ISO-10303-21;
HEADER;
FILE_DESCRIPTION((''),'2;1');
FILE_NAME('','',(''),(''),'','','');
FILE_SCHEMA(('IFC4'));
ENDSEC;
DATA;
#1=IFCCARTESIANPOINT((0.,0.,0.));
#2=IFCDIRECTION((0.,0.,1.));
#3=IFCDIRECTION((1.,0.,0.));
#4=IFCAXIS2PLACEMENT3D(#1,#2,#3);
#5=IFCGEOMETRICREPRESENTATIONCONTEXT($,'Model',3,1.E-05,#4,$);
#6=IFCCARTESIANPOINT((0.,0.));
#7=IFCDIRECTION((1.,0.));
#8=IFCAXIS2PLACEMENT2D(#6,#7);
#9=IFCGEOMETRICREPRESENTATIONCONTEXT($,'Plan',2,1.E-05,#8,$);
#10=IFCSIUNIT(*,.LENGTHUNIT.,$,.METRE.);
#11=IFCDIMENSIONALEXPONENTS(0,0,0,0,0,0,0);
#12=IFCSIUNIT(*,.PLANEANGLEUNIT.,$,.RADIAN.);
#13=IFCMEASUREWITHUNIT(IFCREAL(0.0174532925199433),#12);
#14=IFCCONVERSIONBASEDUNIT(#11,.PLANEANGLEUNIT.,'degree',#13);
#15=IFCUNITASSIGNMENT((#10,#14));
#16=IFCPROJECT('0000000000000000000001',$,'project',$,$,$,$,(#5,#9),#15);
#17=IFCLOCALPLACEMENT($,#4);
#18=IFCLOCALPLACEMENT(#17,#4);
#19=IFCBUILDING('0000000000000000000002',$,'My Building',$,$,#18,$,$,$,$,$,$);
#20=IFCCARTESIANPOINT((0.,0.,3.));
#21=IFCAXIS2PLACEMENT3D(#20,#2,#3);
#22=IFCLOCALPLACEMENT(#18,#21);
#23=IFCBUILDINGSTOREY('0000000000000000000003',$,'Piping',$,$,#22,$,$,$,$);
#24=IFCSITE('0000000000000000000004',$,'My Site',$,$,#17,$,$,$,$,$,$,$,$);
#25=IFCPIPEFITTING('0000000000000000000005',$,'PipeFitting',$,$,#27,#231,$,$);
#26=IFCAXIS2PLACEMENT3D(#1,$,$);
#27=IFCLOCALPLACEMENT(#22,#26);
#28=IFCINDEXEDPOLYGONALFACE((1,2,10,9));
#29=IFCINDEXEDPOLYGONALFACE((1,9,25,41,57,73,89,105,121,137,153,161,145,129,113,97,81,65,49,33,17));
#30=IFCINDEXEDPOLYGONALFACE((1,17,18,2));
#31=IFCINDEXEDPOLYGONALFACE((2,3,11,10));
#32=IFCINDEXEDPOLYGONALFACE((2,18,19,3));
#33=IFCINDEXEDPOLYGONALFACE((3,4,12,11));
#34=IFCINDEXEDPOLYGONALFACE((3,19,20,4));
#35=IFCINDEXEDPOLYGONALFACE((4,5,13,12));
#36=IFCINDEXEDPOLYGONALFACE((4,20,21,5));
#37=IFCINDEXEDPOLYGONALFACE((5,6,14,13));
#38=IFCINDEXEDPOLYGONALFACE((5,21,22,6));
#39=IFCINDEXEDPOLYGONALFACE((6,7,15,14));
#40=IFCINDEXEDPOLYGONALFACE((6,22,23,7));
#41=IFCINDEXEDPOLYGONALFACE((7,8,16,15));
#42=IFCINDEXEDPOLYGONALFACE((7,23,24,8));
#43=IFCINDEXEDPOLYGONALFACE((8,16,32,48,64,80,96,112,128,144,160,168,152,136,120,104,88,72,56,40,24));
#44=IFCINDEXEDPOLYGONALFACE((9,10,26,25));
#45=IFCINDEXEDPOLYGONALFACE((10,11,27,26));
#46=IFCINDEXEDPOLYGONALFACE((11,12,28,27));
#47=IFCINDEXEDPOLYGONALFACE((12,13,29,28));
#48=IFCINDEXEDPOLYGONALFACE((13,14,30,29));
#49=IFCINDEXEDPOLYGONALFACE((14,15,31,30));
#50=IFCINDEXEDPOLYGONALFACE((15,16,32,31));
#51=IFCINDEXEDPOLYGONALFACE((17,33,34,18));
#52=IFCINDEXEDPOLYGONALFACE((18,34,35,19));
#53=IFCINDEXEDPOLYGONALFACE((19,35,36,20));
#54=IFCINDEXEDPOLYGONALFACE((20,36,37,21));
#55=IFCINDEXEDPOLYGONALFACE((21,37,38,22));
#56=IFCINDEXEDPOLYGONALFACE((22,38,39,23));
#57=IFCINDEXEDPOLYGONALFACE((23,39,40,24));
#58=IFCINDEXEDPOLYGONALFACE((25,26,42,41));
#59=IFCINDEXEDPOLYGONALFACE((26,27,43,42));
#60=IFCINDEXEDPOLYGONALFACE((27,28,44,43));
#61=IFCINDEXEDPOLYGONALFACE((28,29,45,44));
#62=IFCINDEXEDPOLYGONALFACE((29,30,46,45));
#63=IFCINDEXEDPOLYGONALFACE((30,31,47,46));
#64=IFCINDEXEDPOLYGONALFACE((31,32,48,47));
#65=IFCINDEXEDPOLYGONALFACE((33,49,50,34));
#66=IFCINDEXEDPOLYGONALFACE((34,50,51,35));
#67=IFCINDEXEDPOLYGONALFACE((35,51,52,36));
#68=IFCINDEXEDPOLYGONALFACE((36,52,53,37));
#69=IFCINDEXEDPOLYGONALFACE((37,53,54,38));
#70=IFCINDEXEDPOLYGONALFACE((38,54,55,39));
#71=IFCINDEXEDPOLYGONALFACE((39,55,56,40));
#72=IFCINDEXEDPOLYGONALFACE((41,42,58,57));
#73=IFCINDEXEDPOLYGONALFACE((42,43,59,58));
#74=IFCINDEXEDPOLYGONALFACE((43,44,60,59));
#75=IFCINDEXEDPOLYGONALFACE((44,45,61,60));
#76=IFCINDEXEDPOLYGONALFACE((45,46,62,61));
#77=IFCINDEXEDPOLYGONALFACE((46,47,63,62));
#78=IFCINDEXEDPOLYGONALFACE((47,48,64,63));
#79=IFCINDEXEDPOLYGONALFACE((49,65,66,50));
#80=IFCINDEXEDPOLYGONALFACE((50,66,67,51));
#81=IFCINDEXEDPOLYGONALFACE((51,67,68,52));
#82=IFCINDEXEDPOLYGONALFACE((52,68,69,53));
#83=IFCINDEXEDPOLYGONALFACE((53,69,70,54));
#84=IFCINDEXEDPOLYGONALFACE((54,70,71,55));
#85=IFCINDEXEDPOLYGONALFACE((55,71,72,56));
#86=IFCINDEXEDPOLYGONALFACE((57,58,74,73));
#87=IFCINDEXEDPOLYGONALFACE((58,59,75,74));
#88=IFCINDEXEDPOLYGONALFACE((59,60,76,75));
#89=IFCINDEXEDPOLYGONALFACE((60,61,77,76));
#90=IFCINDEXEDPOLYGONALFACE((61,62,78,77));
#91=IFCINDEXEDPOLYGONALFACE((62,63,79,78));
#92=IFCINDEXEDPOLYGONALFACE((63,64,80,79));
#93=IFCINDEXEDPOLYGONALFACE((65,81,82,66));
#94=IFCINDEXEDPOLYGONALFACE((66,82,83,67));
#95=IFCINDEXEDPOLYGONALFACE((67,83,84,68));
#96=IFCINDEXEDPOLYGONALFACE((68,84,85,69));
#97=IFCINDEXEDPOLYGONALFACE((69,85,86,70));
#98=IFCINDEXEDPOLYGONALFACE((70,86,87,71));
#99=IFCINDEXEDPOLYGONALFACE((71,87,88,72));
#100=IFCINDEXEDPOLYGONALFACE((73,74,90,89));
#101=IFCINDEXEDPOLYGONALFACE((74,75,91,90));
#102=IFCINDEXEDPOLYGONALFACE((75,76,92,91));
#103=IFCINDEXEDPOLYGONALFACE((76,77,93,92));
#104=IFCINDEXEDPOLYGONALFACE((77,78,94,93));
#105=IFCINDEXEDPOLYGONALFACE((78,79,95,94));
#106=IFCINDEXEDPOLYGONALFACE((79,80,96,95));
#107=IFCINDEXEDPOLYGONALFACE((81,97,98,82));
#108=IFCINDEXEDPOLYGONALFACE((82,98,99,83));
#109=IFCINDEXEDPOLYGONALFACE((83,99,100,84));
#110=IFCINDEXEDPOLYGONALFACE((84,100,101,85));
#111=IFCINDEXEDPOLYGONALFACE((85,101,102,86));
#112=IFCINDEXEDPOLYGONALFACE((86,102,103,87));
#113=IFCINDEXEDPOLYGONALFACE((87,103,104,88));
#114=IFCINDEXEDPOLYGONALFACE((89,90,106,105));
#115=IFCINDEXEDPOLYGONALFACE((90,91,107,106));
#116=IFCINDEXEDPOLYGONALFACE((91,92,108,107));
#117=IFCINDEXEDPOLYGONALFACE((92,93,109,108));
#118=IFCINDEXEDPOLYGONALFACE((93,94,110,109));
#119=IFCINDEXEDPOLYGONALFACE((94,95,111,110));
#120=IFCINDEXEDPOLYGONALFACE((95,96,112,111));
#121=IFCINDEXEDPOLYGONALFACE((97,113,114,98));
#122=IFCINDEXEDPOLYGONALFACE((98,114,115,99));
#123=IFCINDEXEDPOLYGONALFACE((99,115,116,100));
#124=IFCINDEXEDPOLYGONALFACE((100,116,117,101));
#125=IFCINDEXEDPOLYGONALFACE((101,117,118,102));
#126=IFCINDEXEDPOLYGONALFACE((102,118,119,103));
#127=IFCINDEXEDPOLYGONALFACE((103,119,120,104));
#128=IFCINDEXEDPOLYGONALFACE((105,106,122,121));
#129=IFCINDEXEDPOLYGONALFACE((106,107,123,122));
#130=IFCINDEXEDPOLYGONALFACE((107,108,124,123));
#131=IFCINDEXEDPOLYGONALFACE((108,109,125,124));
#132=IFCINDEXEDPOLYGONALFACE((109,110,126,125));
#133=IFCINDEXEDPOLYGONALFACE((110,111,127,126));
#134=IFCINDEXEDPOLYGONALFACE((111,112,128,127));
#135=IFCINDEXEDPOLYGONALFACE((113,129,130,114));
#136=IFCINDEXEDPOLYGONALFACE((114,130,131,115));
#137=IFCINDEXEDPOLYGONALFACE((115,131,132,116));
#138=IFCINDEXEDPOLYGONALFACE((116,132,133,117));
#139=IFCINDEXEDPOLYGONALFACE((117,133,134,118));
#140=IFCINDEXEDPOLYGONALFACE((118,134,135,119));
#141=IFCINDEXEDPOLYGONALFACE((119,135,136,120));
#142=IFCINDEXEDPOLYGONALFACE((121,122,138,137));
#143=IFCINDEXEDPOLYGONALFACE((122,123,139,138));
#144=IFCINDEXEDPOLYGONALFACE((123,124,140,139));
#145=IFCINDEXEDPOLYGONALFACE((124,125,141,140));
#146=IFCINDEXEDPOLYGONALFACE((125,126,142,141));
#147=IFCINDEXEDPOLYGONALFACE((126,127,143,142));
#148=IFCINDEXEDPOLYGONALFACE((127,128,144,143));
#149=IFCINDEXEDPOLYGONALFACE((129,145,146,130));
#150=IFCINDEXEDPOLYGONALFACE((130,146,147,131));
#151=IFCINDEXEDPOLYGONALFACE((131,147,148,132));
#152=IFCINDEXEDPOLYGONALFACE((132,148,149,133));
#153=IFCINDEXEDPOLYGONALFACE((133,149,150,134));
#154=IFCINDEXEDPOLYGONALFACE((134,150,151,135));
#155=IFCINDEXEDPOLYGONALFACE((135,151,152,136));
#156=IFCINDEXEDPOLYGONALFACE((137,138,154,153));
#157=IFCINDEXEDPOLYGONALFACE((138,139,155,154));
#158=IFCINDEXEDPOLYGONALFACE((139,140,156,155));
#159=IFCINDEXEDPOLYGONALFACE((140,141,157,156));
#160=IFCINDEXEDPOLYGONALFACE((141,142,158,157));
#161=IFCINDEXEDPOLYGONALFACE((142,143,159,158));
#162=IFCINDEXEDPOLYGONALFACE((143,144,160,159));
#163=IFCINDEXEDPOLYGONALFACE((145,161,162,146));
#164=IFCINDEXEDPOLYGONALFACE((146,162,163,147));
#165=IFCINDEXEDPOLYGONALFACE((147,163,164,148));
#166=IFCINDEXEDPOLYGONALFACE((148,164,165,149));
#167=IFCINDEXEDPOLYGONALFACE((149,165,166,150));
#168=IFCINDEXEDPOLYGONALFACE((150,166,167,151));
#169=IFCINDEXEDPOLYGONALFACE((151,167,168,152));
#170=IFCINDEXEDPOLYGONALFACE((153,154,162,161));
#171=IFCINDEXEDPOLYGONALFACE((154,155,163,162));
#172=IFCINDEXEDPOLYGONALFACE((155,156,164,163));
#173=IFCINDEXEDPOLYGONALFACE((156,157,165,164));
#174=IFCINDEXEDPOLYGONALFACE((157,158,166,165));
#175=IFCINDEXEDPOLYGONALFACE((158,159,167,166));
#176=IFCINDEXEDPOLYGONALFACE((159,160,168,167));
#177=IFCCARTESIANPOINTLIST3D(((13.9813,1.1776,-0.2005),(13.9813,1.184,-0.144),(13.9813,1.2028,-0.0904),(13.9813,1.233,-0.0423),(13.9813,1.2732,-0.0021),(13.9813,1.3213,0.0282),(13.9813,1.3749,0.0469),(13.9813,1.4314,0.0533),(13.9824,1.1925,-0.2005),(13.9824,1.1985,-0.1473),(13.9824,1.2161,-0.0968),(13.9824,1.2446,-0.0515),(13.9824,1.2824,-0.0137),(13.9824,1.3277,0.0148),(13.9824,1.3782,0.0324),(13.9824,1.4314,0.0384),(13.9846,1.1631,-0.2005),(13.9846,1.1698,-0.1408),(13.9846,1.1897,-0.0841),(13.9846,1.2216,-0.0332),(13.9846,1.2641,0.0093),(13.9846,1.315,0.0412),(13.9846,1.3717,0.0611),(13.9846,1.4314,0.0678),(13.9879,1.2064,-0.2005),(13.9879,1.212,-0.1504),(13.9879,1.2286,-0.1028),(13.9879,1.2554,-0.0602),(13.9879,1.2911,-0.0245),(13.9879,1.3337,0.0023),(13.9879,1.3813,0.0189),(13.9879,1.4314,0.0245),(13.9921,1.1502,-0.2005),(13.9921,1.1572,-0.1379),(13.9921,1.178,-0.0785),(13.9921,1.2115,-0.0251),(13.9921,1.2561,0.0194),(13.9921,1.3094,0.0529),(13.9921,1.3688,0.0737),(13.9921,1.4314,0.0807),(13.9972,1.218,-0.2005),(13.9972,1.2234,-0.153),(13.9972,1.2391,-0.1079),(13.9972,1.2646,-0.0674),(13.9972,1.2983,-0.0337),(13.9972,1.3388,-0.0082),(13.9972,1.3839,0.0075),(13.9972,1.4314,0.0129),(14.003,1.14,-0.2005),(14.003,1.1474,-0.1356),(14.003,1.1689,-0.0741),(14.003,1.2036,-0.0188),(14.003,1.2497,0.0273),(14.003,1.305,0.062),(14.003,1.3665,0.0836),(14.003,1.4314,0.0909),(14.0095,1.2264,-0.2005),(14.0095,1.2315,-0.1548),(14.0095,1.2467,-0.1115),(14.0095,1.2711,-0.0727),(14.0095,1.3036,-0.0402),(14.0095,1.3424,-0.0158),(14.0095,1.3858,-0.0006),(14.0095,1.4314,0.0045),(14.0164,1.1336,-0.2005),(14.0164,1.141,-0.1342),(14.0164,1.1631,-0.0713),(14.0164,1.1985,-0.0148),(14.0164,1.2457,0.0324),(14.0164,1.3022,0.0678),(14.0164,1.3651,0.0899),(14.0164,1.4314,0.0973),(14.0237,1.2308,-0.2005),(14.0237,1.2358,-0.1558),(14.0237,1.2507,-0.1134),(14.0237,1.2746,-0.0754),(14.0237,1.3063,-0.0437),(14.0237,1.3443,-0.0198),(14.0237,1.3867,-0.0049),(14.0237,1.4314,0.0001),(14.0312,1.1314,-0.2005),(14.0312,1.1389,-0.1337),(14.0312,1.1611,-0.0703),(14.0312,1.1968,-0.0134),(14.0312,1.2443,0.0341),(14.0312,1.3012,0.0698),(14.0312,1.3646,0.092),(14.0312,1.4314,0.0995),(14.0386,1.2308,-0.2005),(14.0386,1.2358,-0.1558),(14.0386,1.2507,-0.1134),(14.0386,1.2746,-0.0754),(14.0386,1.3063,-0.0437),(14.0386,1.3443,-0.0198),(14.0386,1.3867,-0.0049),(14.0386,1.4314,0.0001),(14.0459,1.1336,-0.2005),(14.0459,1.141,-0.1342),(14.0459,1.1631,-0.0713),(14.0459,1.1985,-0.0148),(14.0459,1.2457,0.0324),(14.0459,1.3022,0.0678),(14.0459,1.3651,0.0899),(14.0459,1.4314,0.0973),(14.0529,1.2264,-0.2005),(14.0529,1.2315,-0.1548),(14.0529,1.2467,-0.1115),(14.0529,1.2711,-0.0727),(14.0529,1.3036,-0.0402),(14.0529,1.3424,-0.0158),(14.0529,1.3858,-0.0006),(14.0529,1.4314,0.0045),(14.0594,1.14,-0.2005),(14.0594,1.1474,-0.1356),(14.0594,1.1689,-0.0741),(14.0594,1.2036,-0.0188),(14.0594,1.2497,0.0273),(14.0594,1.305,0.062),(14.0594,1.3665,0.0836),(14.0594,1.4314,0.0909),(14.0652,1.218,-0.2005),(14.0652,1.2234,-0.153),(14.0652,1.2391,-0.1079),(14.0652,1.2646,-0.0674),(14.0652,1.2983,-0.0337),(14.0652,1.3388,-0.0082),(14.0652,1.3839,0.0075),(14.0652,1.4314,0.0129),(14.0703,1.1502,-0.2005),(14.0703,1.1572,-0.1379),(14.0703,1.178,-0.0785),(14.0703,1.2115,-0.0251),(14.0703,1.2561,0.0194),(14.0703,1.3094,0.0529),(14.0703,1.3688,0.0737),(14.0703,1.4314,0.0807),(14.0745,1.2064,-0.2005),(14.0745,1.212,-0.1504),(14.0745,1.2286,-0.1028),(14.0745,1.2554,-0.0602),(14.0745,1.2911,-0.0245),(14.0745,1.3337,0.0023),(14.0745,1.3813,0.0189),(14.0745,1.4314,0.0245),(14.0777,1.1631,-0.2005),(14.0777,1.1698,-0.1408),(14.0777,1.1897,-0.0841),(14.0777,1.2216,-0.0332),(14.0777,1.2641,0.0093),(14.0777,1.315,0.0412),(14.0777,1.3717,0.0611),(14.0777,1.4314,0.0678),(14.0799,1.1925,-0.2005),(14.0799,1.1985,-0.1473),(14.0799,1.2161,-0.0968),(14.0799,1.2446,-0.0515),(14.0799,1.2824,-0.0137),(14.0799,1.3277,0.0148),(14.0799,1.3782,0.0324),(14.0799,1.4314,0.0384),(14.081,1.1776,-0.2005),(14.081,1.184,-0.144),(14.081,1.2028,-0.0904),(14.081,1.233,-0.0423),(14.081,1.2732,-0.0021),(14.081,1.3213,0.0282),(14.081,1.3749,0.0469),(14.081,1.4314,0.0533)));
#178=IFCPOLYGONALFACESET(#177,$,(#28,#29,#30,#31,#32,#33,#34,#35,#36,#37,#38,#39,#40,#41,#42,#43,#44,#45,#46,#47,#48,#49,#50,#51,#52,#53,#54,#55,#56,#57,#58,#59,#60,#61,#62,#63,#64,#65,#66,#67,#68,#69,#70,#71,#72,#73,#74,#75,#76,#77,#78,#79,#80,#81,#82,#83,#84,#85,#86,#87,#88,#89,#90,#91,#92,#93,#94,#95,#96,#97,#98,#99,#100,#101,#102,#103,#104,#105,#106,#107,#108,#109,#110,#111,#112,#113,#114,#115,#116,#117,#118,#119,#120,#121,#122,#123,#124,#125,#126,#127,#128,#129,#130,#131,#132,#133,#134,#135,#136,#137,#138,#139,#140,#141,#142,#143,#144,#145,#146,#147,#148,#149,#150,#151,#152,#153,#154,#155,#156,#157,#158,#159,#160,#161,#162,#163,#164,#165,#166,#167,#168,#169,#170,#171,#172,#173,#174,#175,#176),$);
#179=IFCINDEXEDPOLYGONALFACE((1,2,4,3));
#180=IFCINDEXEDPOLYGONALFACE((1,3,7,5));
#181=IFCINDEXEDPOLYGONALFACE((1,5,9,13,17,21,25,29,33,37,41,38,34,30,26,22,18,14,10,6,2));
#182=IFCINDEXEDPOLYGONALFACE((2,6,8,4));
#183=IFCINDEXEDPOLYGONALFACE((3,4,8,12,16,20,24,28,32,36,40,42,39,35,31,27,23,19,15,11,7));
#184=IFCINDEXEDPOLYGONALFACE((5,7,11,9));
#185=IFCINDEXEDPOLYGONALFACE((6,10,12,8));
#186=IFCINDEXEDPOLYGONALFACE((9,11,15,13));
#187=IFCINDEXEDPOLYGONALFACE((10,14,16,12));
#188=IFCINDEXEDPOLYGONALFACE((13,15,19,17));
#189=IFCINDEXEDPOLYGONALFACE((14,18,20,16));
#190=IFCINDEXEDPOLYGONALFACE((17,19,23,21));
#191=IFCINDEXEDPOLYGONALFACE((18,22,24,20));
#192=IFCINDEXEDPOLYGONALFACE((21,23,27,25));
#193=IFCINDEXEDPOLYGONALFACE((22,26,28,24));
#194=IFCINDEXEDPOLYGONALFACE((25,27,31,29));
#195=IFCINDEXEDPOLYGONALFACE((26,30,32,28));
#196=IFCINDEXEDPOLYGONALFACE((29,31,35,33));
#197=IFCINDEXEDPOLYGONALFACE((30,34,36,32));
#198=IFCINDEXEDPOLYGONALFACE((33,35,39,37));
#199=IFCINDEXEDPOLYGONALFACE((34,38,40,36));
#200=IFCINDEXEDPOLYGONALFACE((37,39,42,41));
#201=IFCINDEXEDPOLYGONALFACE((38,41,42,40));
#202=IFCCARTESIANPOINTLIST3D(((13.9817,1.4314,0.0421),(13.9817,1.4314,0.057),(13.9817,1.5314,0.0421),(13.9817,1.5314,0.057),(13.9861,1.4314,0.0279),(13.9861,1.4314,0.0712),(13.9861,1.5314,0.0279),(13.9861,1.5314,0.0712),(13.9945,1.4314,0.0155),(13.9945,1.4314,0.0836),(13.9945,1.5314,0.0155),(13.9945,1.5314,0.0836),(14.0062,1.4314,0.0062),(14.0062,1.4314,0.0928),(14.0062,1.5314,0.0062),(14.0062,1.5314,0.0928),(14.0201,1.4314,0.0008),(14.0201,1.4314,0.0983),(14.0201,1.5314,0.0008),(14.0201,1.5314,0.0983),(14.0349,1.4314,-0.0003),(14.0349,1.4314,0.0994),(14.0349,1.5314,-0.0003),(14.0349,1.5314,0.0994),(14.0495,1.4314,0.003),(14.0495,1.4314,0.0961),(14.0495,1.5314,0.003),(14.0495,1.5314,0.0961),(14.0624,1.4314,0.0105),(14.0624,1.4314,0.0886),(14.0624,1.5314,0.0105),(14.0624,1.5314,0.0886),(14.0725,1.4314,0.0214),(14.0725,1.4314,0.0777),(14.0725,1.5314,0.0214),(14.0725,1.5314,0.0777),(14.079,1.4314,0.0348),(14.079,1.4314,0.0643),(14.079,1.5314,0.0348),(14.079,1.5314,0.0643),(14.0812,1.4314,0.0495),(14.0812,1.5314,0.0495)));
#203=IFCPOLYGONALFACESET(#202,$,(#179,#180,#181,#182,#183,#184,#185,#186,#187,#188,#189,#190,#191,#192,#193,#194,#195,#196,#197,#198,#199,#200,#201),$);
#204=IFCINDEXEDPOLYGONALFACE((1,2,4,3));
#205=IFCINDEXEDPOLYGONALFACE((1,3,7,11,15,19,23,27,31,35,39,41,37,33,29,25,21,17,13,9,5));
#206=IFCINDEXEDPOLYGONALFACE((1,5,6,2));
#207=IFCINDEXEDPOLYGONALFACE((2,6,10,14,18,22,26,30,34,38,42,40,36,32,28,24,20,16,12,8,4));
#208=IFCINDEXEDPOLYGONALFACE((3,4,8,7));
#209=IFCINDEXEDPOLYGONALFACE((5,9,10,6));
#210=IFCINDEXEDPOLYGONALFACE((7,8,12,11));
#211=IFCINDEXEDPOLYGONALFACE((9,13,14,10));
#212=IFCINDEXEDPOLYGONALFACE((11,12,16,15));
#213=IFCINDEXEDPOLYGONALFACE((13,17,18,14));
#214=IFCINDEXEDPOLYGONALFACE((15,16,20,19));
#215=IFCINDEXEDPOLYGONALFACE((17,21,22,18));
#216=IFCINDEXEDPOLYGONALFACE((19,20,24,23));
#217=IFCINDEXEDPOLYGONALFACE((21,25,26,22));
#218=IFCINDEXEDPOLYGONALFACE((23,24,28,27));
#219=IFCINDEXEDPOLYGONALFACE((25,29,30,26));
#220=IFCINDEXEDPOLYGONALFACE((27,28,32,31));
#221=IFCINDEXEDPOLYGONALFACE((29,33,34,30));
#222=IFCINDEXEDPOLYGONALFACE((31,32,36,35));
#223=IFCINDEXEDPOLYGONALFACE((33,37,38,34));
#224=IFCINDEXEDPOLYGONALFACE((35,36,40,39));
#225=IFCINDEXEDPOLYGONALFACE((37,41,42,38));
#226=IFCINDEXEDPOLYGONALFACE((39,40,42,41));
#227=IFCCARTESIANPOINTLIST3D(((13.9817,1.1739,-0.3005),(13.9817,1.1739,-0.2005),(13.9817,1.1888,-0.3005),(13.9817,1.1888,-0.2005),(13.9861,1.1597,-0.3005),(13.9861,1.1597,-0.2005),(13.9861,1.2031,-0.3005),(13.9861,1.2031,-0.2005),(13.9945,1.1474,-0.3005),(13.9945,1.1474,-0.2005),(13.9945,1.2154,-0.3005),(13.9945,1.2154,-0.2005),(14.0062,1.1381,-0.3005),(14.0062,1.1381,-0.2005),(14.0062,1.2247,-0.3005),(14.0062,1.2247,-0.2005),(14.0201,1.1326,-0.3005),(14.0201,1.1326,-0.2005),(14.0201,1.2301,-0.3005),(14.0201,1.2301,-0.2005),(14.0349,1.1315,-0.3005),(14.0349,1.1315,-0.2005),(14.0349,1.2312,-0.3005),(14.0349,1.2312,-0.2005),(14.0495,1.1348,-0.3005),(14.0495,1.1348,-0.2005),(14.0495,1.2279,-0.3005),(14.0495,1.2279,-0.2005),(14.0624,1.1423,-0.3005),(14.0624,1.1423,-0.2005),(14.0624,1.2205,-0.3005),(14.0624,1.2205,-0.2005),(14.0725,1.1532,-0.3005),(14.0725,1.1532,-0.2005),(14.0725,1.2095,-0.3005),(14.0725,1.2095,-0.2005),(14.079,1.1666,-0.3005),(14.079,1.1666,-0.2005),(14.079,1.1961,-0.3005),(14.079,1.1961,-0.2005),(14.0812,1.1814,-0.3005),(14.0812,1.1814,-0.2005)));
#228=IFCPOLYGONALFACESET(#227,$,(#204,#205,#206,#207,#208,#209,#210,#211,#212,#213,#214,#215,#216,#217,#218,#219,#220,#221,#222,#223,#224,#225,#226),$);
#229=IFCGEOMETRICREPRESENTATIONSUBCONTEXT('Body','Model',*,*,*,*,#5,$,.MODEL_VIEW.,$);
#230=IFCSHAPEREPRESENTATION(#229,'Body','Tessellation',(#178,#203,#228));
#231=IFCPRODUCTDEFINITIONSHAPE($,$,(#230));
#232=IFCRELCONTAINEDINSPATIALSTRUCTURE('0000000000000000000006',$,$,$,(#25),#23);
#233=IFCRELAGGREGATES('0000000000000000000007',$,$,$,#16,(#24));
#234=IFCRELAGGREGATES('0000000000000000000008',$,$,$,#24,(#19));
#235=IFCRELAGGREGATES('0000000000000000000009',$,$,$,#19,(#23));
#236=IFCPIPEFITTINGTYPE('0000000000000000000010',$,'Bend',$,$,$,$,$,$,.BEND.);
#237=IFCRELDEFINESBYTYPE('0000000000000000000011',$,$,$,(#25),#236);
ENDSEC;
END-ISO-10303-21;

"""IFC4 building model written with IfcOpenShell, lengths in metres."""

from ifc_helpers import new_model, entity, si_unit, converted_unit, frame, origin_with_axes, origin_2d_with_axis, place, context, subcontext, project, spatial, circle, extrude, source, transform, mapped, type_object, type_shapes, element, save


model = new_model("IFC4")

# Units and contexts
model_context = context("Model", 3, precision=1e-05, world=origin_with_axes())
plan_context = context("Plan", 2, precision=1e-05, world=origin_2d_with_axis())
body_context = subcontext(model_context, "Body", "Model", "MODEL_VIEW")
ifc_project = project(units=[si_unit("LENGTHUNIT", "METRE"), converted_unit("PLANEANGLEUNIT", "degree", entity("IfcReal", 0.0174532925199433), si_unit("PLANEANGLEUNIT", "RADIAN"), dimensions=[0, 0, 0, 0, 0, 0, 0])], contexts=[model_context, plan_context])

# Site, building, storey
site_placement = place(None, origin_with_axes())
site = spatial("IfcSite", under=ifc_project, at=site_placement, Name="My Site")
building_placement = place(site_placement, origin_with_axes())
building = spatial("IfcBuilding", under=site, at=building_placement, Name="My Building")
storey_placement = place(building_placement, frame((0.0, 0.0, 3.0), z_axis=(0.0, 0.0, 1.0), x_axis=(1.0, 0.0, 0.0)))
storey = spatial("IfcBuildingStorey", under=building, at=storey_placement, Name="Piping")

# Pipe fitting
pipe_fitting_type = type_object("IfcPipeFittingType", Name="Bend", PredefinedType="BEND")
shared_shape = source(origin_with_axes(), body_context, "Body", "SolidModel", [
    entity("IfcSweptDiskSolid", entity("IfcIndexedPolyCurve", entity("IfcCartesianPointList3D", [[0.0, 0.0, 0.1], [0.0, -0.0732, 0.2768], [0.0, -0.25, 0.35]]), [entity("IfcArcIndex", [1, 2, 3])]), 0.05),
    extrude(circle(Radius=0.05), origin_with_axes(), (0.0, 0.0, 1.0), 0.1),
    extrude(circle(Radius=0.05), frame((0.0, -0.25, 0.35), z_axis=(0.0, -1.0, 0.0), x_axis=(1.0, 0.0, 0.0)), (0.0, 0.0, 1.0), 0.1),
])
type_shapes(pipe_fitting_type, [shared_shape])
for number, where, z_axis, x_axis, name in (
    (1, (14.0312, 1.5314, 0.0495), (0.0, -1.0, 0.0), (1.0, 0.0, 0.0), "PipeFitting"),
):
    element("IfcPipeFitting", number, at=place(storey_placement, frame(where, z_axis=z_axis, x_axis=x_axis)), inside=storey, type_object=pipe_fitting_type, Name=name, context=body_context, shape_type="MappedRepresentation", body=[
        mapped(shared_shape, transform((0.0, 0.0, 0.0), x_axis=(1.0, 0.0, 0.0), y_axis=(0.0, 1.0, 0.0), z_axis=(0.0, 0.0, 1.0), scale=1.0)),
    ])

save(model, "model.ifc")
